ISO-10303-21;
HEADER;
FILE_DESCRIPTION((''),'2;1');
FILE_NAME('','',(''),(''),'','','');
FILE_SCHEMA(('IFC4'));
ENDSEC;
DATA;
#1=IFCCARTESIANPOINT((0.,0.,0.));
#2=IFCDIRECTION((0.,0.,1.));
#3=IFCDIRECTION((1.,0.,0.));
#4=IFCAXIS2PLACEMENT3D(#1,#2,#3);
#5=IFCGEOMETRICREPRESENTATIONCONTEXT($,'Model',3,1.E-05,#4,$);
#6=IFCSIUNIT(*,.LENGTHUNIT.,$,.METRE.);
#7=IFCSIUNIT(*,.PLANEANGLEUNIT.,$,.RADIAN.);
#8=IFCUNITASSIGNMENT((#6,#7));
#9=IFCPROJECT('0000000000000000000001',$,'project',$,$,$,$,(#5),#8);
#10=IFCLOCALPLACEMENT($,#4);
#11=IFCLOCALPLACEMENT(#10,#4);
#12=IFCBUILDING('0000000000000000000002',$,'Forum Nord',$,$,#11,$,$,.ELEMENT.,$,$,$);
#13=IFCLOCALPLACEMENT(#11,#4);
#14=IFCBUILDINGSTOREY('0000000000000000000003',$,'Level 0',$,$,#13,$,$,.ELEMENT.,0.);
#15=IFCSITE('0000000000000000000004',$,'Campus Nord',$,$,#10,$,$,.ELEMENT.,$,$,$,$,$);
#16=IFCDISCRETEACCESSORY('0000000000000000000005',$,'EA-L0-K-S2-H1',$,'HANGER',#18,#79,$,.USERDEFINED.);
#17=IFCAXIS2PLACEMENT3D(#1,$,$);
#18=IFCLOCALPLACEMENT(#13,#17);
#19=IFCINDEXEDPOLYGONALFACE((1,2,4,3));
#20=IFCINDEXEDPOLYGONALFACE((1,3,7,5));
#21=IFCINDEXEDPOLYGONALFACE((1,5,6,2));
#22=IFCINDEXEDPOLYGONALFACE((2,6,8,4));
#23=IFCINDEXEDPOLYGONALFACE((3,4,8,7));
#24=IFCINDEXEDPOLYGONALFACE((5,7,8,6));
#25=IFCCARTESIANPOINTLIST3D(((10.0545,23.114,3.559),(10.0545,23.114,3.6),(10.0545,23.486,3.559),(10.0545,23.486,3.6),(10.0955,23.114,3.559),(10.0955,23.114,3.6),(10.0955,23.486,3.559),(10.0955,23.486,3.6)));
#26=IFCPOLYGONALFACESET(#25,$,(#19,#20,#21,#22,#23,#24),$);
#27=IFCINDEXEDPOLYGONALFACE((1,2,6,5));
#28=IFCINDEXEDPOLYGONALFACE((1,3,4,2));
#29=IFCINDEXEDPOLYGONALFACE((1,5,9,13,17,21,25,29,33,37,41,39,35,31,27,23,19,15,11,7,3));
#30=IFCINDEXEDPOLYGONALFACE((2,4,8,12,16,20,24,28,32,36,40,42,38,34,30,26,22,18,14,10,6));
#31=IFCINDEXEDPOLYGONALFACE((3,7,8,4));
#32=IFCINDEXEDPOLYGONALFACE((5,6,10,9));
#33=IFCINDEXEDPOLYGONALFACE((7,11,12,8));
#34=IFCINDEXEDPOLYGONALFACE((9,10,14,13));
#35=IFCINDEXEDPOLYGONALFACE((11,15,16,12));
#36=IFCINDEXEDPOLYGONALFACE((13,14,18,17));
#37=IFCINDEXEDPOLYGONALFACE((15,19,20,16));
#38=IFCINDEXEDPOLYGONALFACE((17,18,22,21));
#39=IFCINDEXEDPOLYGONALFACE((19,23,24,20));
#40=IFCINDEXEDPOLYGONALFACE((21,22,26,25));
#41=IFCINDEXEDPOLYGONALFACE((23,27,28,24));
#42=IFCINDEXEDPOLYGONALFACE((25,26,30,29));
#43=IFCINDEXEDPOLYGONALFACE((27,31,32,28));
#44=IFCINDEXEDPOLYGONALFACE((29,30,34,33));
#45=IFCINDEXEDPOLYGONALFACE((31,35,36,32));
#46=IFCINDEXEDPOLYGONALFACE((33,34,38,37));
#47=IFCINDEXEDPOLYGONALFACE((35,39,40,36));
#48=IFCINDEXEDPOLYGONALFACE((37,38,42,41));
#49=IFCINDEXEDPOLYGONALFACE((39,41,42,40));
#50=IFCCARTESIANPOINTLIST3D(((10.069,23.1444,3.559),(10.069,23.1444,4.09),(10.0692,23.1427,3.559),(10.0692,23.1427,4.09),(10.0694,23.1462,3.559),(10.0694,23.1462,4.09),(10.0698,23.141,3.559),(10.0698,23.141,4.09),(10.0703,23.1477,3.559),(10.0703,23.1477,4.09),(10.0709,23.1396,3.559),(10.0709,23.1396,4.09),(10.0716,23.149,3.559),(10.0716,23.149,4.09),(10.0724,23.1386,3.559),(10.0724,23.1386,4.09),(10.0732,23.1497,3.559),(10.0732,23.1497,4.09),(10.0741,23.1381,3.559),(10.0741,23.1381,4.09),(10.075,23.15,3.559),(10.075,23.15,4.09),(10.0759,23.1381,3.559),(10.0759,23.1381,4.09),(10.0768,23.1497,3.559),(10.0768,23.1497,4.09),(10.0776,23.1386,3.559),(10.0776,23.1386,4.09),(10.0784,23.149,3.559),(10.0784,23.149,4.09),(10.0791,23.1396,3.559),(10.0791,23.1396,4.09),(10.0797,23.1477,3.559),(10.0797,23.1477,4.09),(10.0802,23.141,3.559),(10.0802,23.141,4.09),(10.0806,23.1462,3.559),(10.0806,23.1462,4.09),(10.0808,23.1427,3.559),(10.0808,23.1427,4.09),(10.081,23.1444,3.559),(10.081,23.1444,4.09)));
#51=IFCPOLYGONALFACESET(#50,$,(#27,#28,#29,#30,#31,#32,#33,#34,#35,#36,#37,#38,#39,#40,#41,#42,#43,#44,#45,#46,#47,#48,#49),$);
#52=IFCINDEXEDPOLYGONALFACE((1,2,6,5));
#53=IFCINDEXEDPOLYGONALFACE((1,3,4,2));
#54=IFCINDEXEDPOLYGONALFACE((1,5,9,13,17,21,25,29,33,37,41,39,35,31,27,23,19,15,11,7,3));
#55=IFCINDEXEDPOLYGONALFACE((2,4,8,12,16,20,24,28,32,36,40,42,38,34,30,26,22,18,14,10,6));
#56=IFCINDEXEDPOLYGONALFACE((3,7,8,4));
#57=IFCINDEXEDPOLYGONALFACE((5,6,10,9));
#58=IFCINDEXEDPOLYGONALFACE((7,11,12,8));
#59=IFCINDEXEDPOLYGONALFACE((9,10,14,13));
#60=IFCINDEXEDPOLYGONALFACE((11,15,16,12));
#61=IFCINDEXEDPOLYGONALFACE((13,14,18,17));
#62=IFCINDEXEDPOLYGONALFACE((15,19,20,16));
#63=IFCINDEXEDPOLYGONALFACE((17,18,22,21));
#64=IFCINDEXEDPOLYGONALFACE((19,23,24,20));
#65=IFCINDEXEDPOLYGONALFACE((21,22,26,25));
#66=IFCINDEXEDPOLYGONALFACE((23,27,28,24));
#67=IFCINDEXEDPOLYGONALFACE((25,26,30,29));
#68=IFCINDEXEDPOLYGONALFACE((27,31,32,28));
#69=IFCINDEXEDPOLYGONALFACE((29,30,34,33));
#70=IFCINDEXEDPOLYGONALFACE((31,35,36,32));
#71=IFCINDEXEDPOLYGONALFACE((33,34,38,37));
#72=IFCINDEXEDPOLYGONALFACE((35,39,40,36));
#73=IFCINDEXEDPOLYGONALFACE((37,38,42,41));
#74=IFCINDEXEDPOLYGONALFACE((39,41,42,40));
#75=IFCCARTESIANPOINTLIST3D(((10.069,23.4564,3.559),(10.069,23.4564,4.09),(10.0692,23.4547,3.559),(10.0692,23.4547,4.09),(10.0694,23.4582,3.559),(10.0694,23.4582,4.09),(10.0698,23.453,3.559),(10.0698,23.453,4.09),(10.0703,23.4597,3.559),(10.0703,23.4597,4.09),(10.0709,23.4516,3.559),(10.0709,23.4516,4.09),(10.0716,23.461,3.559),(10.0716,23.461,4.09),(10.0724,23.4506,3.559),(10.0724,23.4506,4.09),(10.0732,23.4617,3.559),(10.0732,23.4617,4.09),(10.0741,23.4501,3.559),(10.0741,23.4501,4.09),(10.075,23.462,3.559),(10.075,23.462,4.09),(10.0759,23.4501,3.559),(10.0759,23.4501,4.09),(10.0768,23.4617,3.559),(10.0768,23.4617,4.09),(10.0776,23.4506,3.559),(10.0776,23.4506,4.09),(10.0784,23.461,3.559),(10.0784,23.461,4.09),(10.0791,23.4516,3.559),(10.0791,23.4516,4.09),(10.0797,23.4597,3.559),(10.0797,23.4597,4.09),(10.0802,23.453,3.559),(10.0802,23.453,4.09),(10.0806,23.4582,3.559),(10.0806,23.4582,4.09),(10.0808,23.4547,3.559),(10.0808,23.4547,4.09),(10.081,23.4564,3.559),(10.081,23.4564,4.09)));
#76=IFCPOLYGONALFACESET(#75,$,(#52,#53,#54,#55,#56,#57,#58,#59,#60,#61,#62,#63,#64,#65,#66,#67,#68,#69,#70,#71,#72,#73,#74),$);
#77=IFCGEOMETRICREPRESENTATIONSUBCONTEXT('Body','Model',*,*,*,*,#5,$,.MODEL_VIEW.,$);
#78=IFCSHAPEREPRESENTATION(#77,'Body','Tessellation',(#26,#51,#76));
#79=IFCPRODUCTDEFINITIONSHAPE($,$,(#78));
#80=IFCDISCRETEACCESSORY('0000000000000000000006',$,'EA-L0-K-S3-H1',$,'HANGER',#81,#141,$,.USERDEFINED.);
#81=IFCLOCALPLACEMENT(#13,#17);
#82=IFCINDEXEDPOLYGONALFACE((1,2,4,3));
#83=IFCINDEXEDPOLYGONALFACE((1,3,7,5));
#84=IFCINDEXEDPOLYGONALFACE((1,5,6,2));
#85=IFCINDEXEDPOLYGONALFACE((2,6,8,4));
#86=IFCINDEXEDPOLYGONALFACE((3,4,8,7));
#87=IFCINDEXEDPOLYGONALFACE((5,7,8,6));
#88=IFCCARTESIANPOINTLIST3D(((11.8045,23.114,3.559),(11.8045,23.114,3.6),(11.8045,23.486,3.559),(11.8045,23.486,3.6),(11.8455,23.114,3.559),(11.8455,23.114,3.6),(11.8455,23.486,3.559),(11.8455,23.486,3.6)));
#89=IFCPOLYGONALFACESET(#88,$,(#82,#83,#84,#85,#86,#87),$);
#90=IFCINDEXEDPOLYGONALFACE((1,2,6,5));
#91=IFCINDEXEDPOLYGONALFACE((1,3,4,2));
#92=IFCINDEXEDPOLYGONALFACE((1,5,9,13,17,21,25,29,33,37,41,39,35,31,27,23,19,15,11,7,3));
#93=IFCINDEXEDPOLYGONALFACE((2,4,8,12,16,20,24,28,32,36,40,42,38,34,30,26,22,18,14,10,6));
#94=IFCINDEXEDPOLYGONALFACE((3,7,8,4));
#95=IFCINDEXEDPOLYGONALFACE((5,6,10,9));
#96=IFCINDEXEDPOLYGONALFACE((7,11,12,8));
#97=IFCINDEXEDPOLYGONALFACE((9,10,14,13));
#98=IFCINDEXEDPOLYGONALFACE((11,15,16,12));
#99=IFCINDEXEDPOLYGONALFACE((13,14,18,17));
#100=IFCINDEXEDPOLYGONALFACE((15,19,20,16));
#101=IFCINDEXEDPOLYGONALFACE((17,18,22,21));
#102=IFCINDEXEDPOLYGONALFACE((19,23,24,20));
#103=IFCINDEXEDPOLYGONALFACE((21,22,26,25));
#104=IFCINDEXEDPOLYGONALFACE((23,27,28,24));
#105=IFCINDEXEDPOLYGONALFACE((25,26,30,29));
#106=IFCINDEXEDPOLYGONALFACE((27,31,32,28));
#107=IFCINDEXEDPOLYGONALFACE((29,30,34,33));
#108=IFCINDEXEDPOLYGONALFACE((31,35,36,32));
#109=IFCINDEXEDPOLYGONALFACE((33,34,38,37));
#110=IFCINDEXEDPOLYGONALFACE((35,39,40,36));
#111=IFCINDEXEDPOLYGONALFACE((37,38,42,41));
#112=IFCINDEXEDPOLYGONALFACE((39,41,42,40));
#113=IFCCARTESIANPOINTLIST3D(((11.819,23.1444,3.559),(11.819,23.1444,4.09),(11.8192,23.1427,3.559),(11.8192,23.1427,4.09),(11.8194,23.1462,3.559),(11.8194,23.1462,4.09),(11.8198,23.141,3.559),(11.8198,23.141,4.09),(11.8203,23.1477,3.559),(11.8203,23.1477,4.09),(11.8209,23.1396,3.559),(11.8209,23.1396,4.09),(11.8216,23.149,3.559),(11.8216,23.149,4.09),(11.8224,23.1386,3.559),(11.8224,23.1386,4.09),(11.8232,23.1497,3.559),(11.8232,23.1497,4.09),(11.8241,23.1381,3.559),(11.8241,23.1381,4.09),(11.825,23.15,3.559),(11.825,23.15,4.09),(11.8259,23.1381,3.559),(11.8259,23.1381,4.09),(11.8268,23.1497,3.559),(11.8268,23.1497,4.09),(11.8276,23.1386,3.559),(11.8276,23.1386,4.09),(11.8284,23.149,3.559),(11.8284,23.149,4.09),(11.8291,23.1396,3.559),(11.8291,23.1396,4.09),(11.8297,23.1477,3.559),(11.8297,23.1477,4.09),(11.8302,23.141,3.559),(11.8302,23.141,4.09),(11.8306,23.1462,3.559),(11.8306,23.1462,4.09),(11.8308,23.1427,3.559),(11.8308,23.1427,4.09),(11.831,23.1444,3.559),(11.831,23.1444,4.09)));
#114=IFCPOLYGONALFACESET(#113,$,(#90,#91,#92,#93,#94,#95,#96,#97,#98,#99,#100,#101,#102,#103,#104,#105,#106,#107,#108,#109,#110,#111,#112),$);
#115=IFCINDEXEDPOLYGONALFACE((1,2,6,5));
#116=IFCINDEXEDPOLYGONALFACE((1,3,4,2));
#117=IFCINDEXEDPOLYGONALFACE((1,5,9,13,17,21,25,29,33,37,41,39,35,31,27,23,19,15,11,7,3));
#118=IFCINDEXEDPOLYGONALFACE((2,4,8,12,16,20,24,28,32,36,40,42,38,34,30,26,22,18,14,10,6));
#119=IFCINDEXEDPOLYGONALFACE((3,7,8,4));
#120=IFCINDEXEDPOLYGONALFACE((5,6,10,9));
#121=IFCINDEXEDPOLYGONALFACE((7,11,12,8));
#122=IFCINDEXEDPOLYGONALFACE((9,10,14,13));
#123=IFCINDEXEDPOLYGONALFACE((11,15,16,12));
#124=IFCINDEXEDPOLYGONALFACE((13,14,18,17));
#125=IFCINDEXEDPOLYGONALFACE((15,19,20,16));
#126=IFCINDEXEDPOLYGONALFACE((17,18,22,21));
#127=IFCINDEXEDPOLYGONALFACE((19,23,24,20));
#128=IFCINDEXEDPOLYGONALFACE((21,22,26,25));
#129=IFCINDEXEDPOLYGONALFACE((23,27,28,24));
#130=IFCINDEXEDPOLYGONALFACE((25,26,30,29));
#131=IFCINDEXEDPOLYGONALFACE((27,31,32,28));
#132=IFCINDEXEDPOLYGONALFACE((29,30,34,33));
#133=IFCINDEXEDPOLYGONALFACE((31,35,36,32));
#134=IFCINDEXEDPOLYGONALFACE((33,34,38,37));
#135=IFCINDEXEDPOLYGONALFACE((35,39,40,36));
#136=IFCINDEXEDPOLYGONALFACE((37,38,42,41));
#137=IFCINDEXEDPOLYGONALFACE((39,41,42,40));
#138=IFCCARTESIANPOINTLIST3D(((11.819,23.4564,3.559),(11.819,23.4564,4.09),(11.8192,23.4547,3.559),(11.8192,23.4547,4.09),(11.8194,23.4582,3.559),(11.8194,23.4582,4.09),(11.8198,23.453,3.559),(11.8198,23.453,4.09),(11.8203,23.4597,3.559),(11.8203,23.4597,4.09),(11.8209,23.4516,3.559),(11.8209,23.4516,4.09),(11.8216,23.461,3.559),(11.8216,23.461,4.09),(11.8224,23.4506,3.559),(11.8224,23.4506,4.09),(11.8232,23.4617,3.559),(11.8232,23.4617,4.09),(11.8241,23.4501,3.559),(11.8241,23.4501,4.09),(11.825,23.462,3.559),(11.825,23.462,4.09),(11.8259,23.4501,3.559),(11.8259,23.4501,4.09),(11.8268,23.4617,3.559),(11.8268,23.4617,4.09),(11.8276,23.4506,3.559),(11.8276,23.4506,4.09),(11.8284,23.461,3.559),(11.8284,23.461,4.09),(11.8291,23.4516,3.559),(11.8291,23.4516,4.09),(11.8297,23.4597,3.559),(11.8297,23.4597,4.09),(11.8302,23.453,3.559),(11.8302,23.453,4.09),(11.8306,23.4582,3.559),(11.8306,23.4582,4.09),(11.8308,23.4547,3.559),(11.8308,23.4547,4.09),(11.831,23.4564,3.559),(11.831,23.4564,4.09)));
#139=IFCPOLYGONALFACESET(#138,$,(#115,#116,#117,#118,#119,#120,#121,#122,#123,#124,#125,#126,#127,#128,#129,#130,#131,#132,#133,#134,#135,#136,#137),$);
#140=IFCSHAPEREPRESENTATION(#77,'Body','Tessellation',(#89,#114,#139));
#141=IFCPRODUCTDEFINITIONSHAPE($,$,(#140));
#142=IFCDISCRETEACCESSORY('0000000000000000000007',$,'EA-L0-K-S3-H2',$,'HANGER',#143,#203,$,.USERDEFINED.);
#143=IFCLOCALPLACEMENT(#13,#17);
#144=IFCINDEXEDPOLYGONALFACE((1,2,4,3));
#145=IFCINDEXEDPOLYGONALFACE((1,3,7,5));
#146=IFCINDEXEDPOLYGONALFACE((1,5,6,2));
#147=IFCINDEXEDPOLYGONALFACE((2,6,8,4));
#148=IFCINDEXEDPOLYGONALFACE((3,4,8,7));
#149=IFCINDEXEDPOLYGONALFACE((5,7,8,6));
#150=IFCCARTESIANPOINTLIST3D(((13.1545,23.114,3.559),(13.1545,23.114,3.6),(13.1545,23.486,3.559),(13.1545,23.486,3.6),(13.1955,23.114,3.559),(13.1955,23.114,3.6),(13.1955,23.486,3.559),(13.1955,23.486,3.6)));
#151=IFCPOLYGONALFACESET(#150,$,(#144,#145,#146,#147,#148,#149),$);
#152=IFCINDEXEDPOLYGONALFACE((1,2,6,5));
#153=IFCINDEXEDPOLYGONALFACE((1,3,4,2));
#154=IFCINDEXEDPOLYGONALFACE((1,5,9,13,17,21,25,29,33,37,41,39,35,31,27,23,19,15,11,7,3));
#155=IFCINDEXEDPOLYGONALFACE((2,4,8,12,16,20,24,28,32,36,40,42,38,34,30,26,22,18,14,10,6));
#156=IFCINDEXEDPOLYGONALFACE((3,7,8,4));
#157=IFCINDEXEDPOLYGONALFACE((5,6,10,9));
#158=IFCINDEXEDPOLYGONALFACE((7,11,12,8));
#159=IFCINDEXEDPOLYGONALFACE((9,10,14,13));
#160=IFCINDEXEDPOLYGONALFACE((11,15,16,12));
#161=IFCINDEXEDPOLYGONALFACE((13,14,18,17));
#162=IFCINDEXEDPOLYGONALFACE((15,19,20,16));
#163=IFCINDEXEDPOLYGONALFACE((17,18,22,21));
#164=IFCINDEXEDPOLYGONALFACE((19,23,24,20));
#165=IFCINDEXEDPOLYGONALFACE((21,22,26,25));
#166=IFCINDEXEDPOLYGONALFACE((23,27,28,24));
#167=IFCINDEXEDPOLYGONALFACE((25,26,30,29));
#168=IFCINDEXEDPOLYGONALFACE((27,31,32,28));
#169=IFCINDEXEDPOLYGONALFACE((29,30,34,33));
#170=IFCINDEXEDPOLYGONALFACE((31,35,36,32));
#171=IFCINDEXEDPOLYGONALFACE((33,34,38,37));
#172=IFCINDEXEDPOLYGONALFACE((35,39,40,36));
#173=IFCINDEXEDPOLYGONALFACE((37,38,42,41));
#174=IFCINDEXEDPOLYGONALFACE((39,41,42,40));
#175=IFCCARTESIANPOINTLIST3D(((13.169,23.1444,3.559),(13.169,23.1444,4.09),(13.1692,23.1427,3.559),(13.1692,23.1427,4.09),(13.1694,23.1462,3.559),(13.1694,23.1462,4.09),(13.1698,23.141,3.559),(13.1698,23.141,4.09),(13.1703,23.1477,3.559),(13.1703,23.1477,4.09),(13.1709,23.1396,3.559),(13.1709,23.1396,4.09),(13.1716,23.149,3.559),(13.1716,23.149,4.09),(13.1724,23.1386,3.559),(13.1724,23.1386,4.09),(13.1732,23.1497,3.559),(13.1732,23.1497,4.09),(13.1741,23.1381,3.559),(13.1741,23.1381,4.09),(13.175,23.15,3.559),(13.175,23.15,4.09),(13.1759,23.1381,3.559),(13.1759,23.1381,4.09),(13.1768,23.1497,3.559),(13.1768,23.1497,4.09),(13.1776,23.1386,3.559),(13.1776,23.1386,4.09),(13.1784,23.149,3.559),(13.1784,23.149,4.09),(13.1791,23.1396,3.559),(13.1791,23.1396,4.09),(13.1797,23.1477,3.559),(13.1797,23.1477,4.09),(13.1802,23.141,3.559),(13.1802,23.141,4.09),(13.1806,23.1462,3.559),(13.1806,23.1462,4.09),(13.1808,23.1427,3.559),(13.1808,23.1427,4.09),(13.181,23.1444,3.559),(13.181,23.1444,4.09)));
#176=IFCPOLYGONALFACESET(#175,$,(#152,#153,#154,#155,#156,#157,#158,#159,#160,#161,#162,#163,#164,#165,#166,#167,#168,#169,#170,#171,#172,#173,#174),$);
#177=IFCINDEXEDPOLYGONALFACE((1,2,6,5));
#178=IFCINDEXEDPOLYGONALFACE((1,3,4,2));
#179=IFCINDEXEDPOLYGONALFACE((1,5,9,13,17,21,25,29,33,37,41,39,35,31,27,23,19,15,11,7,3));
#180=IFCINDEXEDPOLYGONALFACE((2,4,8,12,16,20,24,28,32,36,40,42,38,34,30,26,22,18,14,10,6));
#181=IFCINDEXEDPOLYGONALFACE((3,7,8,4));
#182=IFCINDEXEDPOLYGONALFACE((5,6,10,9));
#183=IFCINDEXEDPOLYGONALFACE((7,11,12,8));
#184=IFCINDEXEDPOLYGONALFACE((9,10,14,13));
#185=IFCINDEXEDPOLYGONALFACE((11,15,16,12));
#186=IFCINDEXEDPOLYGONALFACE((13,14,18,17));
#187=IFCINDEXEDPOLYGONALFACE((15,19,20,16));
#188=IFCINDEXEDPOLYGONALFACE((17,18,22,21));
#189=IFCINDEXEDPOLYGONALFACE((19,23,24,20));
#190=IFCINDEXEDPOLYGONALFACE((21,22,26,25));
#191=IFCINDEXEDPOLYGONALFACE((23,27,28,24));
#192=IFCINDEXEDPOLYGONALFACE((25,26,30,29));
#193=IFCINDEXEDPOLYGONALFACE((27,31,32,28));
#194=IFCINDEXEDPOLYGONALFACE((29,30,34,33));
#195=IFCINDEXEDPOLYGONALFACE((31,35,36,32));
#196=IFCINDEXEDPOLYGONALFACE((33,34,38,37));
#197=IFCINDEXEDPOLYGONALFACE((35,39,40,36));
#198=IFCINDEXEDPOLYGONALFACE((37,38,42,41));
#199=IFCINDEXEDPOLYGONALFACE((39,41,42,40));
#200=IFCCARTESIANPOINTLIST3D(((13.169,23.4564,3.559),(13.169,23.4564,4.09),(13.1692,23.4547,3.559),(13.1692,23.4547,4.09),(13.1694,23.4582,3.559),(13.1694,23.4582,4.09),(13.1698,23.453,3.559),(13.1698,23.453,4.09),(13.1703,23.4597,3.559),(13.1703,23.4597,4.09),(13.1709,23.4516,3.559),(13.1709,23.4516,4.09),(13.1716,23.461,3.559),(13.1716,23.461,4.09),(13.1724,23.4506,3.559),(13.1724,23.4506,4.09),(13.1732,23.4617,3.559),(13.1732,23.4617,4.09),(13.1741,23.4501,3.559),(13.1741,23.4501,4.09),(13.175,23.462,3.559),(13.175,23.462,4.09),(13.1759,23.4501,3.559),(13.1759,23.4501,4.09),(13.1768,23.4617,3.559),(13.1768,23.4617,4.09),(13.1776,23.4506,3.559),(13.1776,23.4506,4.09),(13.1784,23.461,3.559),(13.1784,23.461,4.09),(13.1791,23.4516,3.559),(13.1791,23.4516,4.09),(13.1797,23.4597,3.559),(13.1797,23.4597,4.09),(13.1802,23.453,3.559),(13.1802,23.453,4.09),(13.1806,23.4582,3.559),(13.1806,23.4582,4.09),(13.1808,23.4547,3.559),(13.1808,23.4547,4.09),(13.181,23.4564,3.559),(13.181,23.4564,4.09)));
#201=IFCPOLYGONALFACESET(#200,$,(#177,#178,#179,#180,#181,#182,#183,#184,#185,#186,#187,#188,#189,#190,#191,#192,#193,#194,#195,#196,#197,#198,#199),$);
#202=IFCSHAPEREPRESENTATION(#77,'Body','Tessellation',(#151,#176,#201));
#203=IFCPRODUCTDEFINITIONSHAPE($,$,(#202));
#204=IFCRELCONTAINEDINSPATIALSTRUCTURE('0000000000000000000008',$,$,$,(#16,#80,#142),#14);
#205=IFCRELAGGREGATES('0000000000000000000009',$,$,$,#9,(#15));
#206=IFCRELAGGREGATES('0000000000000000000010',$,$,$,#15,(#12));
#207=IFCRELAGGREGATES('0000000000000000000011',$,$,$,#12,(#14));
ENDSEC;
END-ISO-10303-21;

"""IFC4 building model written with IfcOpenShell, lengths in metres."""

from ifc_helpers import new_model, si_unit, frame, frame_2d, origin_with_axes, origin_2d_with_axis, place, context, subcontext, project, spatial, rectangle, circle, extrude, element, save


model = new_model("IFC4")

# Units and contexts
model_context = context("Model", 3, precision=1e-05, world=origin_with_axes())
body_context = subcontext(model_context, "Body", "Model", "MODEL_VIEW")
ifc_project = project(units=[si_unit("LENGTHUNIT", "METRE"), si_unit("PLANEANGLEUNIT", "RADIAN")], contexts=[model_context])

# Site, building, storey
site_placement = place(None, origin_with_axes())
site = spatial("IfcSite", under=ifc_project, at=site_placement, Name="Campus Nord", CompositionType="ELEMENT")
building_placement = place(site_placement, origin_with_axes())
building = spatial("IfcBuilding", under=site, at=building_placement, Name="Forum Nord", CompositionType="ELEMENT")
storey_placement = place(building_placement, origin_with_axes())
storey = spatial("IfcBuildingStorey", under=building, at=storey_placement, Name="Level 0", CompositionType="ELEMENT", Elevation=0.0)

# Discrete accessories
for number, where, z_axis, x_axis, name in (
    (1, (10.075, 23.3, 3.6), (0.0, 0.0, 1.0), (0.0, 1.0, 0.0), "EA-L0-K-S2-H1"),
    (2, (11.825, 23.3, 3.6), (0.0, 0.0, 1.0), (0.0, 1.0, 0.0), "EA-L0-K-S3-H1"),
    (3, (13.175, 23.3, 3.6), (0.0, 0.0, 1.0), (0.0, 1.0, 0.0), "EA-L0-K-S3-H2"),
):
    element("IfcDiscreteAccessory", number, at=place(storey_placement, frame(where, z_axis=z_axis, x_axis=x_axis)), inside=storey, Name=name, ObjectType="HANGER", PredefinedType="USERDEFINED", context=body_context, shape_type="SweptSolid", body=[
        extrude(rectangle(XDim=0.372, YDim=0.041, at=origin_2d_with_axis()), frame((0.0, 0.0, -0.041), z_axis=(0.0, 0.0, 1.0), x_axis=(1.0, 0.0, 0.0)), (0.0, 0.0, 1.0), 0.041),
        extrude(circle(Radius=0.006, at=frame_2d((-0.156, 0.0), x_axis=(1.0, 0.0))), frame((0.0, 0.0, -0.041), z_axis=(0.0, 0.0, 1.0), x_axis=(1.0, 0.0, 0.0)), (0.0, 0.0, 1.0), 0.531),
        extrude(circle(Radius=0.006, at=frame_2d((0.156, 0.0), x_axis=(1.0, 0.0))), frame((0.0, 0.0, -0.041), z_axis=(0.0, 0.0, 1.0), x_axis=(1.0, 0.0, 0.0)), (0.0, 0.0, 1.0), 0.531),
    ])

save(model, "model.ifc")
